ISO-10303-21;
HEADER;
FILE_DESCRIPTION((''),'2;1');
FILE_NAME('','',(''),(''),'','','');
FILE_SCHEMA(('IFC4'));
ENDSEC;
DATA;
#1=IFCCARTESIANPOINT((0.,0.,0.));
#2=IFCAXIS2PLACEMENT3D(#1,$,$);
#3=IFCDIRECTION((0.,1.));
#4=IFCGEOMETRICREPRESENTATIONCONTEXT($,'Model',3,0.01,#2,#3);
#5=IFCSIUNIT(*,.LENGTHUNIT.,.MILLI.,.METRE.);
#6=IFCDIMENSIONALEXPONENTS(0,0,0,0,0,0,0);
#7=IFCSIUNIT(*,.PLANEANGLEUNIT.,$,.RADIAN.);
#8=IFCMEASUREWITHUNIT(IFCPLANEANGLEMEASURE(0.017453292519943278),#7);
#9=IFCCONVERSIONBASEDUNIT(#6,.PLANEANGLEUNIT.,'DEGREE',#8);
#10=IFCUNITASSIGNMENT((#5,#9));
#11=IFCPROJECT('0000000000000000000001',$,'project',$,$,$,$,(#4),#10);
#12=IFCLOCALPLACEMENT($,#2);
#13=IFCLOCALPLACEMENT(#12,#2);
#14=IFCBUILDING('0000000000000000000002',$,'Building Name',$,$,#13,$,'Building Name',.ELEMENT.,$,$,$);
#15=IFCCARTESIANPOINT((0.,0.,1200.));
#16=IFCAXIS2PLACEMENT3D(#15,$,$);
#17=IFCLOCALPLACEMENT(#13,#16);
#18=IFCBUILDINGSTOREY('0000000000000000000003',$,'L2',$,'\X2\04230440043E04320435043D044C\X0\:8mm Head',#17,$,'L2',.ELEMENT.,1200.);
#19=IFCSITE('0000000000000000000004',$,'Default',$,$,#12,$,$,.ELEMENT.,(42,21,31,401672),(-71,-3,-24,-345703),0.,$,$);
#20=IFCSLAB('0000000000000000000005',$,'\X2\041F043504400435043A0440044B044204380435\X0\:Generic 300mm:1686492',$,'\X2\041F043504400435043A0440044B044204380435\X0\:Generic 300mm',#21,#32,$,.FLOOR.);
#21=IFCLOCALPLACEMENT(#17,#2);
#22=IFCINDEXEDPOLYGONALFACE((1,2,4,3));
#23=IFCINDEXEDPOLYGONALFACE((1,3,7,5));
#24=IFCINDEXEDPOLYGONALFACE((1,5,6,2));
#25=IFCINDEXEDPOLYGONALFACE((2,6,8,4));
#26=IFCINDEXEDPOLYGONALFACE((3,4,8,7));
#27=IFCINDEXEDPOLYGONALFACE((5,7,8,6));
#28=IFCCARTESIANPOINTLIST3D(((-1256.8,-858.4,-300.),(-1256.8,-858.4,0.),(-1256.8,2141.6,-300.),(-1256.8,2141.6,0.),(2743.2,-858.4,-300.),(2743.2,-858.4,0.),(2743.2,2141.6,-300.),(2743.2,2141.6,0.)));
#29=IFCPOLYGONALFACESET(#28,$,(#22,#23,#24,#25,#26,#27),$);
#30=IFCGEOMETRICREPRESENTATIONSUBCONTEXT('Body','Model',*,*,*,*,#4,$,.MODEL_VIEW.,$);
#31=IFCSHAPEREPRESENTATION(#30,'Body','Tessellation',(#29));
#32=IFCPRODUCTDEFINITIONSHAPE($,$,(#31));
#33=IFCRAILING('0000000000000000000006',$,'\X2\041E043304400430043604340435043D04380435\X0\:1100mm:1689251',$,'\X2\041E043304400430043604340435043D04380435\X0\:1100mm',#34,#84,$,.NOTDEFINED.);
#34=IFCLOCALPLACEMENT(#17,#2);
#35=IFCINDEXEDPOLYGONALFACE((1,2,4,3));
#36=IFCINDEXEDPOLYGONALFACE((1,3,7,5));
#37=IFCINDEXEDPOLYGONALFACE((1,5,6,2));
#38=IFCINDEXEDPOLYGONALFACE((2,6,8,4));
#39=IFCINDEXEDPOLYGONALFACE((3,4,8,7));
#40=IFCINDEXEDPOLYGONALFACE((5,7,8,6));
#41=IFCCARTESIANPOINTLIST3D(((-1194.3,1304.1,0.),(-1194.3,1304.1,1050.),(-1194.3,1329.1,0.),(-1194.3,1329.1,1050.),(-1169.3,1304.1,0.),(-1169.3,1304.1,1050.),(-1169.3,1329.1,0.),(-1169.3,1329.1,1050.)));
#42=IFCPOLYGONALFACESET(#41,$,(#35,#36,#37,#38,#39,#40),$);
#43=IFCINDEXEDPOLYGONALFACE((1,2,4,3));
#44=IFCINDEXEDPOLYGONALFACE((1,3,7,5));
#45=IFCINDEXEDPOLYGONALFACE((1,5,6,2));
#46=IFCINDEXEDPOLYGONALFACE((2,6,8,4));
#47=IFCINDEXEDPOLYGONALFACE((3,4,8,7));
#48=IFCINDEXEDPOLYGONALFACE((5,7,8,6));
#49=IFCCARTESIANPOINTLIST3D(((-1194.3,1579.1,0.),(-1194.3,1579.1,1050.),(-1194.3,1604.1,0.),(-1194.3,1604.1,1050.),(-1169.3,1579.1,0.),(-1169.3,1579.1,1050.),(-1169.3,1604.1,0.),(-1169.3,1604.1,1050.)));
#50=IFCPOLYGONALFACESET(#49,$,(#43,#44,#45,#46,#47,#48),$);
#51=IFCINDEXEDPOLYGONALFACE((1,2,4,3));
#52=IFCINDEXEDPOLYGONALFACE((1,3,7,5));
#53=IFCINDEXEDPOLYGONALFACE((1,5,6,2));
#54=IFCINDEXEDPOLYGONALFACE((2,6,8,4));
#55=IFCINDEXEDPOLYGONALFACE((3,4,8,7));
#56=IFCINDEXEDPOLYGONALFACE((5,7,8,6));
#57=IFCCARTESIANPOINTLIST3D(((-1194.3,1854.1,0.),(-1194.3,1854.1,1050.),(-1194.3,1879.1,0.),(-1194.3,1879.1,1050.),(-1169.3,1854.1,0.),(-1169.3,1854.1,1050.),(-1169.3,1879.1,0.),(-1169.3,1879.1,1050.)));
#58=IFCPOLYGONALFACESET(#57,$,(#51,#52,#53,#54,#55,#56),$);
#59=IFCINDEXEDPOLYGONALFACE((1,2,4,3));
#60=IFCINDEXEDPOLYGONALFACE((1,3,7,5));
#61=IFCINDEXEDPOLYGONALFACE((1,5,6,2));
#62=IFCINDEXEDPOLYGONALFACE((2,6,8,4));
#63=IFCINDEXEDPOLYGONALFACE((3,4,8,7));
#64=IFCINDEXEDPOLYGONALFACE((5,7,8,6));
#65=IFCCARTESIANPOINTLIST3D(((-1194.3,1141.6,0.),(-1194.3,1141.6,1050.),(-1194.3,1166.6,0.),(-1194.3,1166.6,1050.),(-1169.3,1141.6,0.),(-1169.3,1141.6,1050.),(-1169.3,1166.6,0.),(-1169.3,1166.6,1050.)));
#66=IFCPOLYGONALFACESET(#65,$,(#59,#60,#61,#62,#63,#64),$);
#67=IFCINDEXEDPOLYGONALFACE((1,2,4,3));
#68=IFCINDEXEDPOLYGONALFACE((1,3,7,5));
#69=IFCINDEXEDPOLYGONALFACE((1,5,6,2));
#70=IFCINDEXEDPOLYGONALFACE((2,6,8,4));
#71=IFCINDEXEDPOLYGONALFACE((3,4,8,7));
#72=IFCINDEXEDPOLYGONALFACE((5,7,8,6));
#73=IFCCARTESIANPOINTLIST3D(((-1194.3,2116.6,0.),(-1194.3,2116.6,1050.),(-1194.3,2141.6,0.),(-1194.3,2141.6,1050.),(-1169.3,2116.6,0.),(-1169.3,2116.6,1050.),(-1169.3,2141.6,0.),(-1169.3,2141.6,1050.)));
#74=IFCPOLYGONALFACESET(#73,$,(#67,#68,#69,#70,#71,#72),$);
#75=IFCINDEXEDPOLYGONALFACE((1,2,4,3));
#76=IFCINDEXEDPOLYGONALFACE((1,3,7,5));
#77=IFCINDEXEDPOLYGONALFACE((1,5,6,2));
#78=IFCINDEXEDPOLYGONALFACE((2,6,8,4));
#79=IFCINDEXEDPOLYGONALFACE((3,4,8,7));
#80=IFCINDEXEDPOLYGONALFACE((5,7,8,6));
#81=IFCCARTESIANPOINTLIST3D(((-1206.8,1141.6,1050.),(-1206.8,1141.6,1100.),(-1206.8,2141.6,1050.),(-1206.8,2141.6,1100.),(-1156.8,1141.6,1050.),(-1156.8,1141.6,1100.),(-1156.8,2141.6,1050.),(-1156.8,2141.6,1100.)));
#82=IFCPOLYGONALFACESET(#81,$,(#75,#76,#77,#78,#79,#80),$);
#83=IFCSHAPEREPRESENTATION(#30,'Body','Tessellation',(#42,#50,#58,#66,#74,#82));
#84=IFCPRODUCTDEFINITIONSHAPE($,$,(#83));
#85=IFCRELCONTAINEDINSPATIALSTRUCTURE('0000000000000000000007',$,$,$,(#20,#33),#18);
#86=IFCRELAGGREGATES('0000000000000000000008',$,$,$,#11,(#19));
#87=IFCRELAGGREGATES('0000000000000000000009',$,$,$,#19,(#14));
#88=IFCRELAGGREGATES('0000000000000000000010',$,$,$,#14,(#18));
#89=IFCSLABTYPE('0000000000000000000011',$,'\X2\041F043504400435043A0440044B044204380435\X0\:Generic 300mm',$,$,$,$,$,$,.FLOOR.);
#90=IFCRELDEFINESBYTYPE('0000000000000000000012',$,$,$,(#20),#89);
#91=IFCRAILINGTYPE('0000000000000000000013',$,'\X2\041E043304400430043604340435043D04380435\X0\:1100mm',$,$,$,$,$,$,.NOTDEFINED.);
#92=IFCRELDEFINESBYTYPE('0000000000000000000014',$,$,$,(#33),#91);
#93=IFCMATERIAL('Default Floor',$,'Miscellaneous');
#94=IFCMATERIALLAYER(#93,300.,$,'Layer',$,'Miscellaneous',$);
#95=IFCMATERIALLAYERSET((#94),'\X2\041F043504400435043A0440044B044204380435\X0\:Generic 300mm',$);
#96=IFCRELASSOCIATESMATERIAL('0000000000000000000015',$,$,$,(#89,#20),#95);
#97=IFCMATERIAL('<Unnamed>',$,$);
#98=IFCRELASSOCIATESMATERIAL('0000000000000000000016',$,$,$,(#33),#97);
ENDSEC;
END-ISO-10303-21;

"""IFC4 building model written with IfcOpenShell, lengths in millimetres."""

from ifc_helpers import new_model, entity, si_unit, converted_unit, direction, frame, frame_2d, origin, origin_2d_with_axis, place, context, subcontext, project, spatial, rectangle, extrude, material, layer, layer_set, layer_usage, type_object, element, save


model = new_model("IFC4")

# Units and contexts
model_context = context("Model", 3, precision=0.01, world=origin(), true_north=direction((0.0, 1.0)))
body_context = subcontext(model_context, "Body", "Model", "MODEL_VIEW")
ifc_project = project(units=[si_unit("LENGTHUNIT", "METRE", prefix="MILLI"), converted_unit("PLANEANGLEUNIT", "DEGREE", entity("IfcPlaneAngleMeasure", 0.017453292519943278), si_unit("PLANEANGLEUNIT", "RADIAN"), dimensions=[0, 0, 0, 0, 0, 0, 0])], contexts=[model_context])

# Site, building, storey
site_placement = place(None, origin())
site = spatial("IfcSite", under=ifc_project, at=site_placement, Name="Default", CompositionType="ELEMENT", RefLatitude=(42, 21, 31, 401672), RefLongitude=(-71, -3, -24, -345703), RefElevation=0.0)
building_placement = place(site_placement, origin())
building = spatial("IfcBuilding", under=site, at=building_placement, Name="Building Name", LongName="Building Name", CompositionType="ELEMENT")
storey_placement = place(building_placement, frame((0.0, 0.0, 1200.0)))
storey = spatial("IfcBuildingStorey", under=building, at=storey_placement, Name="L2", ObjectType="Уровень:8mm Head", LongName="L2", CompositionType="ELEMENT", Elevation=1200.0)

# Slab
ifc_material_1 = material(Name="Default Floor", Category="Miscellaneous")
ifc_layer = layer(ifc_material_1, 300.0, Name="Layer", Category="Miscellaneous")
ifc_layer_set = layer_set([ifc_layer], Name="Перекрытие:Generic 300mm")
ifc_layer_usage = layer_usage(ifc_layer_set, "AXIS3", "POSITIVE", 0.0)
slab_type = type_object("IfcSlabType", Name="Перекрытие:Generic 300mm", PredefinedType="FLOOR", material=ifc_layer_set)
slab_placement = place(storey_placement, origin())
element("IfcSlab", 1, at=slab_placement, inside=storey, type_object=slab_type, material=ifc_layer_usage, Name="Перекрытие:Generic 300mm:1686492", ObjectType="Перекрытие:Generic 300mm", PredefinedType="FLOOR", context=body_context, shape_type="SweptSolid", body=[
    extrude(rectangle(XDim=3000.0, YDim=4000.0, at=origin_2d_with_axis()), frame((743.2, 641.6, 0.0), z_axis=(0.0, 0.0, -1.0), x_axis=(0.0, 1.0, 0.0)), (0.0, 0.0, 1.0), 300.0),
])

# Railing
ifc_material_2 = material(Name="<Unnamed>")
railing_type = type_object("IfcRailingType", Name="Ограждение:1100mm", PredefinedType="NOTDEFINED")
railing_placement = place(storey_placement, frame((-1206.8, 1141.6, 0.0)))
element("IfcRailing", 2, at=railing_placement, inside=storey, type_object=railing_type, material=ifc_material_2, Name="Ограждение:1100mm:1689251", ObjectType="Ограждение:1100mm", PredefinedType="NOTDEFINED", context=body_context, shape_type="SweptSolid", body=[
    extrude(rectangle(XDim=25.0, YDim=25.0, at=origin_2d_with_axis()), frame((25.0, 175.0, 0.0), z_axis=(0.0, 0.0, 1.0), x_axis=(0.0, -1.0, 0.0)), (0.0, 0.0, 1.0), 1050.0),
    extrude(rectangle(XDim=25.0, YDim=25.0, at=origin_2d_with_axis()), frame((25.0, 450.0, 0.0), z_axis=(0.0, 0.0, 1.0), x_axis=(0.0, -1.0, 0.0)), (0.0, 0.0, 1.0), 1050.0),
    extrude(rectangle(XDim=25.0, YDim=25.0, at=origin_2d_with_axis()), frame((25.0, 725.0, 0.0), z_axis=(0.0, 0.0, 1.0), x_axis=(0.0, -1.0, 0.0)), (0.0, 0.0, 1.0), 1050.0),
    extrude(rectangle(XDim=25.0, YDim=25.0, at=frame_2d((0.0, 0.0), x_axis=(1.0, 0.0))), frame((25.0, 12.5, 0.0), z_axis=(0.0, 0.0, 1.0), x_axis=(0.0, -1.0, 0.0)), (0.0, 0.0, 1.0), 1050.0),
    extrude(rectangle(XDim=25.0, YDim=25.0, at=origin_2d_with_axis()), frame((25.0, 987.5, 0.0), z_axis=(0.0, 0.0, 1.0), x_axis=(0.0, -1.0, 0.0)), (0.0, 0.0, 1.0), 1050.0),
    extrude(rectangle(XDim=1000.0, YDim=50.0, at=origin_2d_with_axis()), frame((25.0, 500.0, 1050.0), z_axis=(0.0, 0.0, 1.0), x_axis=(0.0, -1.0, 0.0)), (0.0, 0.0, 1.0), 50.0),
])

save(model, "model.ifc")
